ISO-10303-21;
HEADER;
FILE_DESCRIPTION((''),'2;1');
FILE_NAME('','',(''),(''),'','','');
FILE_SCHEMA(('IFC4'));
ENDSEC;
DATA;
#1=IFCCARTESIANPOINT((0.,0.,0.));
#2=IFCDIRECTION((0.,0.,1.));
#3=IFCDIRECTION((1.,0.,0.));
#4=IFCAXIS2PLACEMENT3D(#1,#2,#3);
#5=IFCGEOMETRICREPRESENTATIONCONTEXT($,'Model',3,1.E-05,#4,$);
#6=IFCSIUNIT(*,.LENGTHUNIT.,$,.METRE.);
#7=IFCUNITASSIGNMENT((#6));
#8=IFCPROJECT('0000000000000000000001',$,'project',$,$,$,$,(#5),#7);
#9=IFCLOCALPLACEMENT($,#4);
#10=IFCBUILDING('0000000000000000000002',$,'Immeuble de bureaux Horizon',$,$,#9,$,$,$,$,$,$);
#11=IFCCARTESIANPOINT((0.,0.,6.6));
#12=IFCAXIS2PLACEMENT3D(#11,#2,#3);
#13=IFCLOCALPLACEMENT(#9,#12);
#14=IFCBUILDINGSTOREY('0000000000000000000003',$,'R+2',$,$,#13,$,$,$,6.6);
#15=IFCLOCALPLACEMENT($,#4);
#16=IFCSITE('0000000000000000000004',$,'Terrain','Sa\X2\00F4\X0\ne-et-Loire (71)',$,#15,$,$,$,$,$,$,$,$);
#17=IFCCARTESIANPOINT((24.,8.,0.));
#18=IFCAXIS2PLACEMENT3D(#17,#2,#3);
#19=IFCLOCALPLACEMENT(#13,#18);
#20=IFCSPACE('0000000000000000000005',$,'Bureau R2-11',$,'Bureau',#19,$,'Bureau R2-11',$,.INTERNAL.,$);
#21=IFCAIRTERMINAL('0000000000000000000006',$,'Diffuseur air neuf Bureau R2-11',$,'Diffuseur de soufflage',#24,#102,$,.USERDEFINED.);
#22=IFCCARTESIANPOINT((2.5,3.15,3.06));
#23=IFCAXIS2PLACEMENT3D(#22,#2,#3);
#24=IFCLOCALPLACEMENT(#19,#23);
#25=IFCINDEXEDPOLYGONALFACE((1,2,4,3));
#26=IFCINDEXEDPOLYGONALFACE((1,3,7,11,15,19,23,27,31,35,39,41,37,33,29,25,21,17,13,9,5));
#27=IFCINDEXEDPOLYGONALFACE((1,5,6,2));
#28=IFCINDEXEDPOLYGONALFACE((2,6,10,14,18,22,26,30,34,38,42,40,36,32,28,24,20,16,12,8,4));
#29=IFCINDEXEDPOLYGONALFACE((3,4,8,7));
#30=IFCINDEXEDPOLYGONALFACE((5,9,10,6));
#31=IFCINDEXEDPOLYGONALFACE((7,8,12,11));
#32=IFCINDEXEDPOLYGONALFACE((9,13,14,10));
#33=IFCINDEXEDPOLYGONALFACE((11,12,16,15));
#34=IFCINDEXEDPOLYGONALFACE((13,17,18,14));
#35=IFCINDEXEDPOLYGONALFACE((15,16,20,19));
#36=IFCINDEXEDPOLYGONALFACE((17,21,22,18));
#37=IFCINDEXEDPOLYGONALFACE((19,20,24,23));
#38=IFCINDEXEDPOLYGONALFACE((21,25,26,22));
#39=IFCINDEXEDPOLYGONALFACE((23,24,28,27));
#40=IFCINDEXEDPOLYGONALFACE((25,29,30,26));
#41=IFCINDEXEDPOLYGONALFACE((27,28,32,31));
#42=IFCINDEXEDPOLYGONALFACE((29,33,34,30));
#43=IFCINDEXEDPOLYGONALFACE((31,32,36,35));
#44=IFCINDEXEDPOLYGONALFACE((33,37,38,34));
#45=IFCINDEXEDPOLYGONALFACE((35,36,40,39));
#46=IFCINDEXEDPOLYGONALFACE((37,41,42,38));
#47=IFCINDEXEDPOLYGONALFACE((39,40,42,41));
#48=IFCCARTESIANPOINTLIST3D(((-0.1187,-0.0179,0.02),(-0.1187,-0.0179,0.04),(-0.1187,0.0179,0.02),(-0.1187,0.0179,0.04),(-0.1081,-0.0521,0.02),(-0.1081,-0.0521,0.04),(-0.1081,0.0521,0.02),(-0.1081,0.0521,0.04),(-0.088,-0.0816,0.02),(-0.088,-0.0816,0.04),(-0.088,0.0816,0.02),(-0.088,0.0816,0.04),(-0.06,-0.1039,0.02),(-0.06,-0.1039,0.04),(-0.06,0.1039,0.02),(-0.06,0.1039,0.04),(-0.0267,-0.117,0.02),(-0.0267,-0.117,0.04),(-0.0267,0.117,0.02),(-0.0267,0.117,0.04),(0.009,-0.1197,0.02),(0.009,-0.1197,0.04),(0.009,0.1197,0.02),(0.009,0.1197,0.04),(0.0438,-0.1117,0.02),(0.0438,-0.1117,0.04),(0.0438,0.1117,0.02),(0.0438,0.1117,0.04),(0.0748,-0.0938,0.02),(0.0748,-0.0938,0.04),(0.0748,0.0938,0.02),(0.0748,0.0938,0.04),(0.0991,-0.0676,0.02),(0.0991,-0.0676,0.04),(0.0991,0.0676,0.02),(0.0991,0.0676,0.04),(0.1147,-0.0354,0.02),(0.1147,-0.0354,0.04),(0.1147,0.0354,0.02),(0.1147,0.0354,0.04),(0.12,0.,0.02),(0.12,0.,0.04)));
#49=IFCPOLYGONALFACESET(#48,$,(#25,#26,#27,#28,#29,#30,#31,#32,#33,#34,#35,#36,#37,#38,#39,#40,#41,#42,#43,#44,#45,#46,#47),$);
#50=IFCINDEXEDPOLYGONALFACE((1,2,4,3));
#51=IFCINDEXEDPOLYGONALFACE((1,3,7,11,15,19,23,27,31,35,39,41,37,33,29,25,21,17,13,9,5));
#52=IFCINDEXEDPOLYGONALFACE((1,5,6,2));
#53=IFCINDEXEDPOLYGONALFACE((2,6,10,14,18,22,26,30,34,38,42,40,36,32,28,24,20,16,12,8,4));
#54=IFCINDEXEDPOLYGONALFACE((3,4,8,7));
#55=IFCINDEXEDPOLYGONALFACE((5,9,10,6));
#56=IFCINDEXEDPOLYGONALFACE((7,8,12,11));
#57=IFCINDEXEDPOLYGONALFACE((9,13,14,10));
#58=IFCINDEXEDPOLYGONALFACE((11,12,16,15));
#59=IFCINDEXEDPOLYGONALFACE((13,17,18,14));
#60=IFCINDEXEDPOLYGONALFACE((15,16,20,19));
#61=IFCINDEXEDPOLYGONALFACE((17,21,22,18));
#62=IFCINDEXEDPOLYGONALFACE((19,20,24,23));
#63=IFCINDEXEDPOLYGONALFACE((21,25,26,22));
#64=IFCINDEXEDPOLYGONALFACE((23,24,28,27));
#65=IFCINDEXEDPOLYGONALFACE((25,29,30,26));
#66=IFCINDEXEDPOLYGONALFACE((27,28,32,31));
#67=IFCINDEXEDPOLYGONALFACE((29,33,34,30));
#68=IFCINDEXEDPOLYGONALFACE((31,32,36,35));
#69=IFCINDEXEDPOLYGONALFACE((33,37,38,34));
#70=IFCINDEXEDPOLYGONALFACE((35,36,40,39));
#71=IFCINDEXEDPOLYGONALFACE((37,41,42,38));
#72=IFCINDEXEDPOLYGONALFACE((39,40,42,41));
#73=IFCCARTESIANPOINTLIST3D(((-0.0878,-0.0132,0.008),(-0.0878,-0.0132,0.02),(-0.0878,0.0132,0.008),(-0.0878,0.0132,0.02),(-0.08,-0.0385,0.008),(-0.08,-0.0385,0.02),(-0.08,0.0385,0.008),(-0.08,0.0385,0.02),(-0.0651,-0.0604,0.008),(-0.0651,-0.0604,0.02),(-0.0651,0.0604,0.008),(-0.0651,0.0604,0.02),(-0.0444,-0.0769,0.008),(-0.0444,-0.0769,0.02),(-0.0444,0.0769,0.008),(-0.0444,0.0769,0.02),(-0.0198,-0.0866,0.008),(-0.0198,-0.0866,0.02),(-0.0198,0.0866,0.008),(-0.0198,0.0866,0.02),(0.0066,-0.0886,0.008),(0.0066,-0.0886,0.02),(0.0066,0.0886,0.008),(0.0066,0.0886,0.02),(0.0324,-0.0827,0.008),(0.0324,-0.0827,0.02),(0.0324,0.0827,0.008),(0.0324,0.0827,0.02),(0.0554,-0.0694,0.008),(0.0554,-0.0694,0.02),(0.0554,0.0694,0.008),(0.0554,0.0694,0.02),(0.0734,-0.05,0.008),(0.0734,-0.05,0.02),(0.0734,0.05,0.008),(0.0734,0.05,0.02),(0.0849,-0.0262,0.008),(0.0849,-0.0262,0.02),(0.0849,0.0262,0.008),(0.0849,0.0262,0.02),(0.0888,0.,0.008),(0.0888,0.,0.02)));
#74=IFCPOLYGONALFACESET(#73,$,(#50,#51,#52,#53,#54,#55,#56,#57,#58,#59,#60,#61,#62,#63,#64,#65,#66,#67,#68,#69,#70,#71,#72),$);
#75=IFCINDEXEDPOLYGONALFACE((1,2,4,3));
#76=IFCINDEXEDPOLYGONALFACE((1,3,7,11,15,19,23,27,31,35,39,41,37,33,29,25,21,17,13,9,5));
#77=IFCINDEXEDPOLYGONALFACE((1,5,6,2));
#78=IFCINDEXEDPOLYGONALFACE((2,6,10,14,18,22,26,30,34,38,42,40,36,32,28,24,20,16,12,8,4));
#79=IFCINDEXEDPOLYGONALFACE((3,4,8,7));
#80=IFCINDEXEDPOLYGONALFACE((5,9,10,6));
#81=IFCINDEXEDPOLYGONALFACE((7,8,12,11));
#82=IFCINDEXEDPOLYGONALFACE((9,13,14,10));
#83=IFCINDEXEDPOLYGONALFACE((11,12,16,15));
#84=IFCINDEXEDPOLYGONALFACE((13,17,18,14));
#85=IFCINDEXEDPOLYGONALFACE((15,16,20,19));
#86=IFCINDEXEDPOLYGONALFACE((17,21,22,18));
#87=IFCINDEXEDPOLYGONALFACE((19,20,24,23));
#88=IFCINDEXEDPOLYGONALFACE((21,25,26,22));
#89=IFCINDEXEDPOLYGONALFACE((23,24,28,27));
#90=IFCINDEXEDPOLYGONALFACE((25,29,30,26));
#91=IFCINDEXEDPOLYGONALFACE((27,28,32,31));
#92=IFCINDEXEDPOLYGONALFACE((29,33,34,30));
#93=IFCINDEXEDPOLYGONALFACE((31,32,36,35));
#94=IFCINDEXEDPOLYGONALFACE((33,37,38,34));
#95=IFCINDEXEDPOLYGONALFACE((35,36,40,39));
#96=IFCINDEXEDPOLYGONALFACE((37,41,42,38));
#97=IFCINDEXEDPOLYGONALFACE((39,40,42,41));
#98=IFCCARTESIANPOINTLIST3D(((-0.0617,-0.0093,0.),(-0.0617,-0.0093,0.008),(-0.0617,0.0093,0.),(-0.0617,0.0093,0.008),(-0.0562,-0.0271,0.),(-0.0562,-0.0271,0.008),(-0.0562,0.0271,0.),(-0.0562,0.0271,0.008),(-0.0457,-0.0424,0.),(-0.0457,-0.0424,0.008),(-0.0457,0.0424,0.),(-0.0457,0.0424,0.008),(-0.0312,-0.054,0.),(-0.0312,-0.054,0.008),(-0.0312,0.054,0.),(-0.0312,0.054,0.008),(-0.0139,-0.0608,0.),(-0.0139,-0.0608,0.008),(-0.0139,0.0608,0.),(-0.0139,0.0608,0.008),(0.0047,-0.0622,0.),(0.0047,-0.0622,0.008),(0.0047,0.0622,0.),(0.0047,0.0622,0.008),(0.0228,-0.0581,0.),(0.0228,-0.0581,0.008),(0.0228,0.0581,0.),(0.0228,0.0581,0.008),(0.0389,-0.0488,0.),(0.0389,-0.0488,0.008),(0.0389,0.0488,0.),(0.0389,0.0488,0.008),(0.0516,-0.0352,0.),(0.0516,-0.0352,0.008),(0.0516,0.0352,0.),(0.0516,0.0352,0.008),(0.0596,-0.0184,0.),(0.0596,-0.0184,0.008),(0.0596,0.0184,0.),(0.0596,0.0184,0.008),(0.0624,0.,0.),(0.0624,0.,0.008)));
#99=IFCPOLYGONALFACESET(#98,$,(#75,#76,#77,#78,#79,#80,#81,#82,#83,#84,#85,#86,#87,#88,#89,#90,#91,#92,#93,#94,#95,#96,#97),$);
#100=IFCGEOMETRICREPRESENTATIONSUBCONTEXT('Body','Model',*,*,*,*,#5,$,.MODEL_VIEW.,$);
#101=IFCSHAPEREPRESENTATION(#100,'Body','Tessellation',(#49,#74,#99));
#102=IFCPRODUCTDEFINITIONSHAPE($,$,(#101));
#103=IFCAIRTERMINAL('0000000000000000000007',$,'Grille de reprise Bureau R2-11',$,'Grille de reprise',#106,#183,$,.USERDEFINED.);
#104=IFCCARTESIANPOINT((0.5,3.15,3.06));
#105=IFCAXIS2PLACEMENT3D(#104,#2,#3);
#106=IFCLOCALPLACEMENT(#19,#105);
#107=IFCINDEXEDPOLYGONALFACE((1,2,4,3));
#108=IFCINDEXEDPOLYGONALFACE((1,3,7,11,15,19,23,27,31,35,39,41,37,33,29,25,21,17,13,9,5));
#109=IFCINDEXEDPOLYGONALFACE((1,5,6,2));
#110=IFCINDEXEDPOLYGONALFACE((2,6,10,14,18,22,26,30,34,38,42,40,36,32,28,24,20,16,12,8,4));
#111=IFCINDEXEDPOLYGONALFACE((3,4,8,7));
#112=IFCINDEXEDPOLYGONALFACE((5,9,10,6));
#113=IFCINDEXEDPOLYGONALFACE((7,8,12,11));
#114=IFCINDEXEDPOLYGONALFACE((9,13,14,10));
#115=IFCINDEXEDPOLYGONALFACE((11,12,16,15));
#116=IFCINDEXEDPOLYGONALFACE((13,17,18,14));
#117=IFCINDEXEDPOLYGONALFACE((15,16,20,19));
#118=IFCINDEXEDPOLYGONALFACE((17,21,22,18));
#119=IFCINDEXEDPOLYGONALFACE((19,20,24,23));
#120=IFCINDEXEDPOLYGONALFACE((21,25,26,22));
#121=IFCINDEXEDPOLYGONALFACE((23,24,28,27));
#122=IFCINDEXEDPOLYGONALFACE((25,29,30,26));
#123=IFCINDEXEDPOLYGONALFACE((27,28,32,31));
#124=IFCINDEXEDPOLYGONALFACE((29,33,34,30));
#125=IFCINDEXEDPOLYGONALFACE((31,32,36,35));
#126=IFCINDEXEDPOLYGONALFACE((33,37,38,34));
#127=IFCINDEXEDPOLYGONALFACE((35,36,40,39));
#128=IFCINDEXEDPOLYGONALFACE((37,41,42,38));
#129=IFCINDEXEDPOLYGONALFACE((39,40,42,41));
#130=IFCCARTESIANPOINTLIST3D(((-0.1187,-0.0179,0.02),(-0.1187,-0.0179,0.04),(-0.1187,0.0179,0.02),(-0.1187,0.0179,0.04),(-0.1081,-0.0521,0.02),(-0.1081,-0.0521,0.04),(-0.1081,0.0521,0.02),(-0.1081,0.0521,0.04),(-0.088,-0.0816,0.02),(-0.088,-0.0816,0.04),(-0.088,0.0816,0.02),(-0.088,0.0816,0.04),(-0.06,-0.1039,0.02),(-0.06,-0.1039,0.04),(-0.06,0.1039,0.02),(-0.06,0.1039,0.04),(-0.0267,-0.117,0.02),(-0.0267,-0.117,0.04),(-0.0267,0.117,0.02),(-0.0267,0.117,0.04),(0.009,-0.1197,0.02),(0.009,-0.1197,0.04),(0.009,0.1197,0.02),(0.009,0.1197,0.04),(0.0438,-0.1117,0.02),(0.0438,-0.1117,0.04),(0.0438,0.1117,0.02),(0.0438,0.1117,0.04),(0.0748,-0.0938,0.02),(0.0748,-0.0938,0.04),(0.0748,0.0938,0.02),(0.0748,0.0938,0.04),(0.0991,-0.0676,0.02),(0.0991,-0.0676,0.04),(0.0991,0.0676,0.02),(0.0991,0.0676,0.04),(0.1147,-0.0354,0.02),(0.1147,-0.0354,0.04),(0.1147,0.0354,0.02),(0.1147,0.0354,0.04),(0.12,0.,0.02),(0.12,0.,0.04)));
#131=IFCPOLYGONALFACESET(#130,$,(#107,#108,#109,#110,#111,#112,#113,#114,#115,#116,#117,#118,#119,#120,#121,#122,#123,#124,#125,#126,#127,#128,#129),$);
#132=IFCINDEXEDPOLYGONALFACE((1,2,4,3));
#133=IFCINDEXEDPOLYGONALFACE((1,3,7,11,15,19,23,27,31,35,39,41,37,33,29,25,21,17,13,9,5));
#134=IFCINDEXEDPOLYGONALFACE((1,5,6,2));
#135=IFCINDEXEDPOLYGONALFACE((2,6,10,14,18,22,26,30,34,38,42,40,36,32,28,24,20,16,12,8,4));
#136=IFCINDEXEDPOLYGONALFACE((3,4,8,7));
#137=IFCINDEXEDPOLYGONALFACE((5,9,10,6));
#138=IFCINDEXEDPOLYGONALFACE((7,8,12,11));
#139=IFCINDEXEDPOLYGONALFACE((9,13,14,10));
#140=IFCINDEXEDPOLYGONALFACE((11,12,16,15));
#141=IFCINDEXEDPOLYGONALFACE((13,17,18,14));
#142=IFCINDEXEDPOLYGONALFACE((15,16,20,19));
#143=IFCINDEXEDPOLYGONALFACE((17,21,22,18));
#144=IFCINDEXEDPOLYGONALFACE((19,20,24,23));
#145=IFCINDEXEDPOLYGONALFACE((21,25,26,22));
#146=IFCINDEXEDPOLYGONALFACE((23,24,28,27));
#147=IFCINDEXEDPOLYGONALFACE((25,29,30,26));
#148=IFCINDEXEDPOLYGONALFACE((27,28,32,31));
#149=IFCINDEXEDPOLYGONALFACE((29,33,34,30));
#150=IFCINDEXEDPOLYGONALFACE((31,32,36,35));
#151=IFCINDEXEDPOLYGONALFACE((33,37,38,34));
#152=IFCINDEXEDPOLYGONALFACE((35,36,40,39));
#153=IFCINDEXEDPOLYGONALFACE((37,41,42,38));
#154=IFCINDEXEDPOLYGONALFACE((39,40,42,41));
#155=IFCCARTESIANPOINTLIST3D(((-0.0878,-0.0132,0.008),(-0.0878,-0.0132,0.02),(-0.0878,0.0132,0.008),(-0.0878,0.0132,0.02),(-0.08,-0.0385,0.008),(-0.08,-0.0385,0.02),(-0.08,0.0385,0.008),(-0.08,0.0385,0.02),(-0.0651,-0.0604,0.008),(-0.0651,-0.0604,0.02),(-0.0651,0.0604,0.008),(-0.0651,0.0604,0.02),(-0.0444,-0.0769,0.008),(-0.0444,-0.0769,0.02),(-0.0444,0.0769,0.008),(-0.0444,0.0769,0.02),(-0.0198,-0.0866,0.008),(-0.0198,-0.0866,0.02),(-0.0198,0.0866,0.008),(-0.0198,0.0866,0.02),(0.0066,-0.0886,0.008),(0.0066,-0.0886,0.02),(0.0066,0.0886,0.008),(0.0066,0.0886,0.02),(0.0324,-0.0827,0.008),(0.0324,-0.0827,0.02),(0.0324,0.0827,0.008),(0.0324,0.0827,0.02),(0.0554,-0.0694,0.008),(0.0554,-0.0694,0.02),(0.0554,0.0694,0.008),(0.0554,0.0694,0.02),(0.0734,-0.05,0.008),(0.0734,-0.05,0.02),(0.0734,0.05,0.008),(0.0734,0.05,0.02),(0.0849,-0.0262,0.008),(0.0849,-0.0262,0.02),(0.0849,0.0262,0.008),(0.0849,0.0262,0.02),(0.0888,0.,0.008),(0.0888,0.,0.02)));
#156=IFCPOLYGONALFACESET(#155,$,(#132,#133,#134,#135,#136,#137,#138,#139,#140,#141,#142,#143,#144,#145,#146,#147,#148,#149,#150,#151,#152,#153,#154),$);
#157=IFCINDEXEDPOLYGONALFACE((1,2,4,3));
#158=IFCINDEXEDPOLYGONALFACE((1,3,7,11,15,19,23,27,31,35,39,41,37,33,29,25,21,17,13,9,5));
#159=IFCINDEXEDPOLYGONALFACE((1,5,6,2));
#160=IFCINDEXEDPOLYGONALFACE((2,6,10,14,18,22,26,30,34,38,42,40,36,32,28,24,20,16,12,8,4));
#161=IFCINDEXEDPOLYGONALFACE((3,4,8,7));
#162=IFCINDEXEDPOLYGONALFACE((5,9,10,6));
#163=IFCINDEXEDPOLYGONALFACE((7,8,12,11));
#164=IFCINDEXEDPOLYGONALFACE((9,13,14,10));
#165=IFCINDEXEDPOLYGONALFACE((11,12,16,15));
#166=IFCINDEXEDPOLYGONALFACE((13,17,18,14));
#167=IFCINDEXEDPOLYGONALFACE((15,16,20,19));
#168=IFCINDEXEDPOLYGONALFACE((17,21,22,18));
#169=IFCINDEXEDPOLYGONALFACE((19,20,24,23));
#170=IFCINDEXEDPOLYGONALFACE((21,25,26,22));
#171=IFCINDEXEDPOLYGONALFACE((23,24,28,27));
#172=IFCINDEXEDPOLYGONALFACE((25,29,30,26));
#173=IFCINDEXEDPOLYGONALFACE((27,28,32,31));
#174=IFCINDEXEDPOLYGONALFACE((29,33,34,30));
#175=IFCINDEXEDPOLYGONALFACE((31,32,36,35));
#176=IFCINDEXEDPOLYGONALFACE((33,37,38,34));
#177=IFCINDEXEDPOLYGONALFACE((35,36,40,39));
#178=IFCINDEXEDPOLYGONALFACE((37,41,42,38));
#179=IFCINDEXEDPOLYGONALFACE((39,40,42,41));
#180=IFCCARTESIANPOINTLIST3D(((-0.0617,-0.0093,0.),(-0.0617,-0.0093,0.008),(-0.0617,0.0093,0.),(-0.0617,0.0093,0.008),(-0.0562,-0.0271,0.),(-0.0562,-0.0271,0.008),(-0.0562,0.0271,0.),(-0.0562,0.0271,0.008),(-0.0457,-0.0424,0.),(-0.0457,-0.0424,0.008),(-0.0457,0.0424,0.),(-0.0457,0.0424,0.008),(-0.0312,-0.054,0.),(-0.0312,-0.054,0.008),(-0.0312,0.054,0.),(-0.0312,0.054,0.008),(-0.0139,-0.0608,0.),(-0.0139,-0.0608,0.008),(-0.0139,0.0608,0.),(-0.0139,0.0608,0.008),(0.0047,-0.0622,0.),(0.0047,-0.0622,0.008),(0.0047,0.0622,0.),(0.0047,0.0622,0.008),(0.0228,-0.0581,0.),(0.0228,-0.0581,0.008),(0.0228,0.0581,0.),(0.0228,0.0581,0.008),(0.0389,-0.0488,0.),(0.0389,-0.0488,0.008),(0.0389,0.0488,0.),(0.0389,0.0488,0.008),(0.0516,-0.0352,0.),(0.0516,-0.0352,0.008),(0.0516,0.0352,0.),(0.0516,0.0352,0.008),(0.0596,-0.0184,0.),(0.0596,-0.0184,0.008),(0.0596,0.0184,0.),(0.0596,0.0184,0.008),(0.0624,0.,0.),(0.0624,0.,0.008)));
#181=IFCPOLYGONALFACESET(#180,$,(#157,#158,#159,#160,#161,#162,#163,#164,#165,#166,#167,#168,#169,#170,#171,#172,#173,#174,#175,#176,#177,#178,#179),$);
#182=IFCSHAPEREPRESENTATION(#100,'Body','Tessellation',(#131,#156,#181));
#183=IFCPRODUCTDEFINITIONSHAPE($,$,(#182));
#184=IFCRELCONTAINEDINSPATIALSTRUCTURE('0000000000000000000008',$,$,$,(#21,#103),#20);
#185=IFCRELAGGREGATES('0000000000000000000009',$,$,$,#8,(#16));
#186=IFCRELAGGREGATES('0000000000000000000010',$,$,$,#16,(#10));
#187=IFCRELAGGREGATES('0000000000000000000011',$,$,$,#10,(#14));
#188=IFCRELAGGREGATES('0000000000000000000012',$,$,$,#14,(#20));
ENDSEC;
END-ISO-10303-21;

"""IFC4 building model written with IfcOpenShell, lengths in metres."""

from ifc_helpers import new_model, si_unit, frame, origin_with_axes, place, context, subcontext, project, spatial, circle, extrude, element, save


model = new_model("IFC4")

# Units and contexts
model_context = context("Model", 3, precision=1e-05, world=origin_with_axes())
body_context = subcontext(model_context, "Body", "Model", "MODEL_VIEW")
ifc_project = project(units=[si_unit("LENGTHUNIT", "METRE")], contexts=[model_context])

# Site, building, storey
site_placement = place(None, origin_with_axes())
site = spatial("IfcSite", under=ifc_project, at=site_placement, Name="Terrain", Description="Saône-et-Loire (71)")
building_placement = place(None, origin_with_axes())
building = spatial("IfcBuilding", under=site, at=building_placement, Name="Immeuble de bureaux Horizon")
storey_placement = place(building_placement, frame((0.0, 0.0, 6.6), z_axis=(0.0, 0.0, 1.0), x_axis=(1.0, 0.0, 0.0)))
storey = spatial("IfcBuildingStorey", under=building, at=storey_placement, Name="R+2", Elevation=6.6)

# Shared definitions
space_1_placement = place(storey_placement, frame((24.0, 8.0, 0.0), z_axis=(0.0, 0.0, 1.0), x_axis=(1.0, 0.0, 0.0)))
space_1 = spatial("IfcSpace", under=storey, at=space_1_placement, Name="Bureau R2-11", ObjectType="Bureau", LongName="Bureau R2-11", PredefinedType="INTERNAL")

# Air terminal
air_terminal_1_placement = place(space_1_placement, frame((2.5, 3.15, 3.06), z_axis=(0.0, 0.0, 1.0), x_axis=(1.0, 0.0, 0.0)))
element("IfcAirTerminal", 1, at=air_terminal_1_placement, inside=space_1, Name="Diffuseur air neuf Bureau R2-11", ObjectType="Diffuseur de soufflage", PredefinedType="USERDEFINED", context=body_context, shape_type="SweptSolid", body=[
    extrude(circle(Radius=0.12), frame((0.0, 0.0, 0.02), z_axis=(0.0, 0.0, 1.0), x_axis=(1.0, 0.0, 0.0)), (0.0, 0.0, 1.0), 0.02),
    extrude(circle(Radius=0.0888), frame((0.0, 0.0, 0.008), z_axis=(0.0, 0.0, 1.0), x_axis=(1.0, 0.0, 0.0)), (0.0, 0.0, 1.0), 0.012),
    extrude(circle(Radius=0.0624), origin_with_axes(), (0.0, 0.0, 1.0), 0.008),
])

# Air terminal
air_terminal_2_placement = place(space_1_placement, frame((0.5, 3.15, 3.06), z_axis=(0.0, 0.0, 1.0), x_axis=(1.0, 0.0, 0.0)))
element("IfcAirTerminal", 2, at=air_terminal_2_placement, inside=space_1, Name="Grille de reprise Bureau R2-11", ObjectType="Grille de reprise", PredefinedType="USERDEFINED", context=body_context, shape_type="SweptSolid", body=[
    extrude(circle(Radius=0.12), frame((0.0, 0.0, 0.02), z_axis=(0.0, 0.0, 1.0), x_axis=(1.0, 0.0, 0.0)), (0.0, 0.0, 1.0), 0.02),
    extrude(circle(Radius=0.0888), frame((0.0, 0.0, 0.008), z_axis=(0.0, 0.0, 1.0), x_axis=(1.0, 0.0, 0.0)), (0.0, 0.0, 1.0), 0.012),
    extrude(circle(Radius=0.0624), origin_with_axes(), (0.0, 0.0, 1.0), 0.008),
])

save(model, "model.ifc")
